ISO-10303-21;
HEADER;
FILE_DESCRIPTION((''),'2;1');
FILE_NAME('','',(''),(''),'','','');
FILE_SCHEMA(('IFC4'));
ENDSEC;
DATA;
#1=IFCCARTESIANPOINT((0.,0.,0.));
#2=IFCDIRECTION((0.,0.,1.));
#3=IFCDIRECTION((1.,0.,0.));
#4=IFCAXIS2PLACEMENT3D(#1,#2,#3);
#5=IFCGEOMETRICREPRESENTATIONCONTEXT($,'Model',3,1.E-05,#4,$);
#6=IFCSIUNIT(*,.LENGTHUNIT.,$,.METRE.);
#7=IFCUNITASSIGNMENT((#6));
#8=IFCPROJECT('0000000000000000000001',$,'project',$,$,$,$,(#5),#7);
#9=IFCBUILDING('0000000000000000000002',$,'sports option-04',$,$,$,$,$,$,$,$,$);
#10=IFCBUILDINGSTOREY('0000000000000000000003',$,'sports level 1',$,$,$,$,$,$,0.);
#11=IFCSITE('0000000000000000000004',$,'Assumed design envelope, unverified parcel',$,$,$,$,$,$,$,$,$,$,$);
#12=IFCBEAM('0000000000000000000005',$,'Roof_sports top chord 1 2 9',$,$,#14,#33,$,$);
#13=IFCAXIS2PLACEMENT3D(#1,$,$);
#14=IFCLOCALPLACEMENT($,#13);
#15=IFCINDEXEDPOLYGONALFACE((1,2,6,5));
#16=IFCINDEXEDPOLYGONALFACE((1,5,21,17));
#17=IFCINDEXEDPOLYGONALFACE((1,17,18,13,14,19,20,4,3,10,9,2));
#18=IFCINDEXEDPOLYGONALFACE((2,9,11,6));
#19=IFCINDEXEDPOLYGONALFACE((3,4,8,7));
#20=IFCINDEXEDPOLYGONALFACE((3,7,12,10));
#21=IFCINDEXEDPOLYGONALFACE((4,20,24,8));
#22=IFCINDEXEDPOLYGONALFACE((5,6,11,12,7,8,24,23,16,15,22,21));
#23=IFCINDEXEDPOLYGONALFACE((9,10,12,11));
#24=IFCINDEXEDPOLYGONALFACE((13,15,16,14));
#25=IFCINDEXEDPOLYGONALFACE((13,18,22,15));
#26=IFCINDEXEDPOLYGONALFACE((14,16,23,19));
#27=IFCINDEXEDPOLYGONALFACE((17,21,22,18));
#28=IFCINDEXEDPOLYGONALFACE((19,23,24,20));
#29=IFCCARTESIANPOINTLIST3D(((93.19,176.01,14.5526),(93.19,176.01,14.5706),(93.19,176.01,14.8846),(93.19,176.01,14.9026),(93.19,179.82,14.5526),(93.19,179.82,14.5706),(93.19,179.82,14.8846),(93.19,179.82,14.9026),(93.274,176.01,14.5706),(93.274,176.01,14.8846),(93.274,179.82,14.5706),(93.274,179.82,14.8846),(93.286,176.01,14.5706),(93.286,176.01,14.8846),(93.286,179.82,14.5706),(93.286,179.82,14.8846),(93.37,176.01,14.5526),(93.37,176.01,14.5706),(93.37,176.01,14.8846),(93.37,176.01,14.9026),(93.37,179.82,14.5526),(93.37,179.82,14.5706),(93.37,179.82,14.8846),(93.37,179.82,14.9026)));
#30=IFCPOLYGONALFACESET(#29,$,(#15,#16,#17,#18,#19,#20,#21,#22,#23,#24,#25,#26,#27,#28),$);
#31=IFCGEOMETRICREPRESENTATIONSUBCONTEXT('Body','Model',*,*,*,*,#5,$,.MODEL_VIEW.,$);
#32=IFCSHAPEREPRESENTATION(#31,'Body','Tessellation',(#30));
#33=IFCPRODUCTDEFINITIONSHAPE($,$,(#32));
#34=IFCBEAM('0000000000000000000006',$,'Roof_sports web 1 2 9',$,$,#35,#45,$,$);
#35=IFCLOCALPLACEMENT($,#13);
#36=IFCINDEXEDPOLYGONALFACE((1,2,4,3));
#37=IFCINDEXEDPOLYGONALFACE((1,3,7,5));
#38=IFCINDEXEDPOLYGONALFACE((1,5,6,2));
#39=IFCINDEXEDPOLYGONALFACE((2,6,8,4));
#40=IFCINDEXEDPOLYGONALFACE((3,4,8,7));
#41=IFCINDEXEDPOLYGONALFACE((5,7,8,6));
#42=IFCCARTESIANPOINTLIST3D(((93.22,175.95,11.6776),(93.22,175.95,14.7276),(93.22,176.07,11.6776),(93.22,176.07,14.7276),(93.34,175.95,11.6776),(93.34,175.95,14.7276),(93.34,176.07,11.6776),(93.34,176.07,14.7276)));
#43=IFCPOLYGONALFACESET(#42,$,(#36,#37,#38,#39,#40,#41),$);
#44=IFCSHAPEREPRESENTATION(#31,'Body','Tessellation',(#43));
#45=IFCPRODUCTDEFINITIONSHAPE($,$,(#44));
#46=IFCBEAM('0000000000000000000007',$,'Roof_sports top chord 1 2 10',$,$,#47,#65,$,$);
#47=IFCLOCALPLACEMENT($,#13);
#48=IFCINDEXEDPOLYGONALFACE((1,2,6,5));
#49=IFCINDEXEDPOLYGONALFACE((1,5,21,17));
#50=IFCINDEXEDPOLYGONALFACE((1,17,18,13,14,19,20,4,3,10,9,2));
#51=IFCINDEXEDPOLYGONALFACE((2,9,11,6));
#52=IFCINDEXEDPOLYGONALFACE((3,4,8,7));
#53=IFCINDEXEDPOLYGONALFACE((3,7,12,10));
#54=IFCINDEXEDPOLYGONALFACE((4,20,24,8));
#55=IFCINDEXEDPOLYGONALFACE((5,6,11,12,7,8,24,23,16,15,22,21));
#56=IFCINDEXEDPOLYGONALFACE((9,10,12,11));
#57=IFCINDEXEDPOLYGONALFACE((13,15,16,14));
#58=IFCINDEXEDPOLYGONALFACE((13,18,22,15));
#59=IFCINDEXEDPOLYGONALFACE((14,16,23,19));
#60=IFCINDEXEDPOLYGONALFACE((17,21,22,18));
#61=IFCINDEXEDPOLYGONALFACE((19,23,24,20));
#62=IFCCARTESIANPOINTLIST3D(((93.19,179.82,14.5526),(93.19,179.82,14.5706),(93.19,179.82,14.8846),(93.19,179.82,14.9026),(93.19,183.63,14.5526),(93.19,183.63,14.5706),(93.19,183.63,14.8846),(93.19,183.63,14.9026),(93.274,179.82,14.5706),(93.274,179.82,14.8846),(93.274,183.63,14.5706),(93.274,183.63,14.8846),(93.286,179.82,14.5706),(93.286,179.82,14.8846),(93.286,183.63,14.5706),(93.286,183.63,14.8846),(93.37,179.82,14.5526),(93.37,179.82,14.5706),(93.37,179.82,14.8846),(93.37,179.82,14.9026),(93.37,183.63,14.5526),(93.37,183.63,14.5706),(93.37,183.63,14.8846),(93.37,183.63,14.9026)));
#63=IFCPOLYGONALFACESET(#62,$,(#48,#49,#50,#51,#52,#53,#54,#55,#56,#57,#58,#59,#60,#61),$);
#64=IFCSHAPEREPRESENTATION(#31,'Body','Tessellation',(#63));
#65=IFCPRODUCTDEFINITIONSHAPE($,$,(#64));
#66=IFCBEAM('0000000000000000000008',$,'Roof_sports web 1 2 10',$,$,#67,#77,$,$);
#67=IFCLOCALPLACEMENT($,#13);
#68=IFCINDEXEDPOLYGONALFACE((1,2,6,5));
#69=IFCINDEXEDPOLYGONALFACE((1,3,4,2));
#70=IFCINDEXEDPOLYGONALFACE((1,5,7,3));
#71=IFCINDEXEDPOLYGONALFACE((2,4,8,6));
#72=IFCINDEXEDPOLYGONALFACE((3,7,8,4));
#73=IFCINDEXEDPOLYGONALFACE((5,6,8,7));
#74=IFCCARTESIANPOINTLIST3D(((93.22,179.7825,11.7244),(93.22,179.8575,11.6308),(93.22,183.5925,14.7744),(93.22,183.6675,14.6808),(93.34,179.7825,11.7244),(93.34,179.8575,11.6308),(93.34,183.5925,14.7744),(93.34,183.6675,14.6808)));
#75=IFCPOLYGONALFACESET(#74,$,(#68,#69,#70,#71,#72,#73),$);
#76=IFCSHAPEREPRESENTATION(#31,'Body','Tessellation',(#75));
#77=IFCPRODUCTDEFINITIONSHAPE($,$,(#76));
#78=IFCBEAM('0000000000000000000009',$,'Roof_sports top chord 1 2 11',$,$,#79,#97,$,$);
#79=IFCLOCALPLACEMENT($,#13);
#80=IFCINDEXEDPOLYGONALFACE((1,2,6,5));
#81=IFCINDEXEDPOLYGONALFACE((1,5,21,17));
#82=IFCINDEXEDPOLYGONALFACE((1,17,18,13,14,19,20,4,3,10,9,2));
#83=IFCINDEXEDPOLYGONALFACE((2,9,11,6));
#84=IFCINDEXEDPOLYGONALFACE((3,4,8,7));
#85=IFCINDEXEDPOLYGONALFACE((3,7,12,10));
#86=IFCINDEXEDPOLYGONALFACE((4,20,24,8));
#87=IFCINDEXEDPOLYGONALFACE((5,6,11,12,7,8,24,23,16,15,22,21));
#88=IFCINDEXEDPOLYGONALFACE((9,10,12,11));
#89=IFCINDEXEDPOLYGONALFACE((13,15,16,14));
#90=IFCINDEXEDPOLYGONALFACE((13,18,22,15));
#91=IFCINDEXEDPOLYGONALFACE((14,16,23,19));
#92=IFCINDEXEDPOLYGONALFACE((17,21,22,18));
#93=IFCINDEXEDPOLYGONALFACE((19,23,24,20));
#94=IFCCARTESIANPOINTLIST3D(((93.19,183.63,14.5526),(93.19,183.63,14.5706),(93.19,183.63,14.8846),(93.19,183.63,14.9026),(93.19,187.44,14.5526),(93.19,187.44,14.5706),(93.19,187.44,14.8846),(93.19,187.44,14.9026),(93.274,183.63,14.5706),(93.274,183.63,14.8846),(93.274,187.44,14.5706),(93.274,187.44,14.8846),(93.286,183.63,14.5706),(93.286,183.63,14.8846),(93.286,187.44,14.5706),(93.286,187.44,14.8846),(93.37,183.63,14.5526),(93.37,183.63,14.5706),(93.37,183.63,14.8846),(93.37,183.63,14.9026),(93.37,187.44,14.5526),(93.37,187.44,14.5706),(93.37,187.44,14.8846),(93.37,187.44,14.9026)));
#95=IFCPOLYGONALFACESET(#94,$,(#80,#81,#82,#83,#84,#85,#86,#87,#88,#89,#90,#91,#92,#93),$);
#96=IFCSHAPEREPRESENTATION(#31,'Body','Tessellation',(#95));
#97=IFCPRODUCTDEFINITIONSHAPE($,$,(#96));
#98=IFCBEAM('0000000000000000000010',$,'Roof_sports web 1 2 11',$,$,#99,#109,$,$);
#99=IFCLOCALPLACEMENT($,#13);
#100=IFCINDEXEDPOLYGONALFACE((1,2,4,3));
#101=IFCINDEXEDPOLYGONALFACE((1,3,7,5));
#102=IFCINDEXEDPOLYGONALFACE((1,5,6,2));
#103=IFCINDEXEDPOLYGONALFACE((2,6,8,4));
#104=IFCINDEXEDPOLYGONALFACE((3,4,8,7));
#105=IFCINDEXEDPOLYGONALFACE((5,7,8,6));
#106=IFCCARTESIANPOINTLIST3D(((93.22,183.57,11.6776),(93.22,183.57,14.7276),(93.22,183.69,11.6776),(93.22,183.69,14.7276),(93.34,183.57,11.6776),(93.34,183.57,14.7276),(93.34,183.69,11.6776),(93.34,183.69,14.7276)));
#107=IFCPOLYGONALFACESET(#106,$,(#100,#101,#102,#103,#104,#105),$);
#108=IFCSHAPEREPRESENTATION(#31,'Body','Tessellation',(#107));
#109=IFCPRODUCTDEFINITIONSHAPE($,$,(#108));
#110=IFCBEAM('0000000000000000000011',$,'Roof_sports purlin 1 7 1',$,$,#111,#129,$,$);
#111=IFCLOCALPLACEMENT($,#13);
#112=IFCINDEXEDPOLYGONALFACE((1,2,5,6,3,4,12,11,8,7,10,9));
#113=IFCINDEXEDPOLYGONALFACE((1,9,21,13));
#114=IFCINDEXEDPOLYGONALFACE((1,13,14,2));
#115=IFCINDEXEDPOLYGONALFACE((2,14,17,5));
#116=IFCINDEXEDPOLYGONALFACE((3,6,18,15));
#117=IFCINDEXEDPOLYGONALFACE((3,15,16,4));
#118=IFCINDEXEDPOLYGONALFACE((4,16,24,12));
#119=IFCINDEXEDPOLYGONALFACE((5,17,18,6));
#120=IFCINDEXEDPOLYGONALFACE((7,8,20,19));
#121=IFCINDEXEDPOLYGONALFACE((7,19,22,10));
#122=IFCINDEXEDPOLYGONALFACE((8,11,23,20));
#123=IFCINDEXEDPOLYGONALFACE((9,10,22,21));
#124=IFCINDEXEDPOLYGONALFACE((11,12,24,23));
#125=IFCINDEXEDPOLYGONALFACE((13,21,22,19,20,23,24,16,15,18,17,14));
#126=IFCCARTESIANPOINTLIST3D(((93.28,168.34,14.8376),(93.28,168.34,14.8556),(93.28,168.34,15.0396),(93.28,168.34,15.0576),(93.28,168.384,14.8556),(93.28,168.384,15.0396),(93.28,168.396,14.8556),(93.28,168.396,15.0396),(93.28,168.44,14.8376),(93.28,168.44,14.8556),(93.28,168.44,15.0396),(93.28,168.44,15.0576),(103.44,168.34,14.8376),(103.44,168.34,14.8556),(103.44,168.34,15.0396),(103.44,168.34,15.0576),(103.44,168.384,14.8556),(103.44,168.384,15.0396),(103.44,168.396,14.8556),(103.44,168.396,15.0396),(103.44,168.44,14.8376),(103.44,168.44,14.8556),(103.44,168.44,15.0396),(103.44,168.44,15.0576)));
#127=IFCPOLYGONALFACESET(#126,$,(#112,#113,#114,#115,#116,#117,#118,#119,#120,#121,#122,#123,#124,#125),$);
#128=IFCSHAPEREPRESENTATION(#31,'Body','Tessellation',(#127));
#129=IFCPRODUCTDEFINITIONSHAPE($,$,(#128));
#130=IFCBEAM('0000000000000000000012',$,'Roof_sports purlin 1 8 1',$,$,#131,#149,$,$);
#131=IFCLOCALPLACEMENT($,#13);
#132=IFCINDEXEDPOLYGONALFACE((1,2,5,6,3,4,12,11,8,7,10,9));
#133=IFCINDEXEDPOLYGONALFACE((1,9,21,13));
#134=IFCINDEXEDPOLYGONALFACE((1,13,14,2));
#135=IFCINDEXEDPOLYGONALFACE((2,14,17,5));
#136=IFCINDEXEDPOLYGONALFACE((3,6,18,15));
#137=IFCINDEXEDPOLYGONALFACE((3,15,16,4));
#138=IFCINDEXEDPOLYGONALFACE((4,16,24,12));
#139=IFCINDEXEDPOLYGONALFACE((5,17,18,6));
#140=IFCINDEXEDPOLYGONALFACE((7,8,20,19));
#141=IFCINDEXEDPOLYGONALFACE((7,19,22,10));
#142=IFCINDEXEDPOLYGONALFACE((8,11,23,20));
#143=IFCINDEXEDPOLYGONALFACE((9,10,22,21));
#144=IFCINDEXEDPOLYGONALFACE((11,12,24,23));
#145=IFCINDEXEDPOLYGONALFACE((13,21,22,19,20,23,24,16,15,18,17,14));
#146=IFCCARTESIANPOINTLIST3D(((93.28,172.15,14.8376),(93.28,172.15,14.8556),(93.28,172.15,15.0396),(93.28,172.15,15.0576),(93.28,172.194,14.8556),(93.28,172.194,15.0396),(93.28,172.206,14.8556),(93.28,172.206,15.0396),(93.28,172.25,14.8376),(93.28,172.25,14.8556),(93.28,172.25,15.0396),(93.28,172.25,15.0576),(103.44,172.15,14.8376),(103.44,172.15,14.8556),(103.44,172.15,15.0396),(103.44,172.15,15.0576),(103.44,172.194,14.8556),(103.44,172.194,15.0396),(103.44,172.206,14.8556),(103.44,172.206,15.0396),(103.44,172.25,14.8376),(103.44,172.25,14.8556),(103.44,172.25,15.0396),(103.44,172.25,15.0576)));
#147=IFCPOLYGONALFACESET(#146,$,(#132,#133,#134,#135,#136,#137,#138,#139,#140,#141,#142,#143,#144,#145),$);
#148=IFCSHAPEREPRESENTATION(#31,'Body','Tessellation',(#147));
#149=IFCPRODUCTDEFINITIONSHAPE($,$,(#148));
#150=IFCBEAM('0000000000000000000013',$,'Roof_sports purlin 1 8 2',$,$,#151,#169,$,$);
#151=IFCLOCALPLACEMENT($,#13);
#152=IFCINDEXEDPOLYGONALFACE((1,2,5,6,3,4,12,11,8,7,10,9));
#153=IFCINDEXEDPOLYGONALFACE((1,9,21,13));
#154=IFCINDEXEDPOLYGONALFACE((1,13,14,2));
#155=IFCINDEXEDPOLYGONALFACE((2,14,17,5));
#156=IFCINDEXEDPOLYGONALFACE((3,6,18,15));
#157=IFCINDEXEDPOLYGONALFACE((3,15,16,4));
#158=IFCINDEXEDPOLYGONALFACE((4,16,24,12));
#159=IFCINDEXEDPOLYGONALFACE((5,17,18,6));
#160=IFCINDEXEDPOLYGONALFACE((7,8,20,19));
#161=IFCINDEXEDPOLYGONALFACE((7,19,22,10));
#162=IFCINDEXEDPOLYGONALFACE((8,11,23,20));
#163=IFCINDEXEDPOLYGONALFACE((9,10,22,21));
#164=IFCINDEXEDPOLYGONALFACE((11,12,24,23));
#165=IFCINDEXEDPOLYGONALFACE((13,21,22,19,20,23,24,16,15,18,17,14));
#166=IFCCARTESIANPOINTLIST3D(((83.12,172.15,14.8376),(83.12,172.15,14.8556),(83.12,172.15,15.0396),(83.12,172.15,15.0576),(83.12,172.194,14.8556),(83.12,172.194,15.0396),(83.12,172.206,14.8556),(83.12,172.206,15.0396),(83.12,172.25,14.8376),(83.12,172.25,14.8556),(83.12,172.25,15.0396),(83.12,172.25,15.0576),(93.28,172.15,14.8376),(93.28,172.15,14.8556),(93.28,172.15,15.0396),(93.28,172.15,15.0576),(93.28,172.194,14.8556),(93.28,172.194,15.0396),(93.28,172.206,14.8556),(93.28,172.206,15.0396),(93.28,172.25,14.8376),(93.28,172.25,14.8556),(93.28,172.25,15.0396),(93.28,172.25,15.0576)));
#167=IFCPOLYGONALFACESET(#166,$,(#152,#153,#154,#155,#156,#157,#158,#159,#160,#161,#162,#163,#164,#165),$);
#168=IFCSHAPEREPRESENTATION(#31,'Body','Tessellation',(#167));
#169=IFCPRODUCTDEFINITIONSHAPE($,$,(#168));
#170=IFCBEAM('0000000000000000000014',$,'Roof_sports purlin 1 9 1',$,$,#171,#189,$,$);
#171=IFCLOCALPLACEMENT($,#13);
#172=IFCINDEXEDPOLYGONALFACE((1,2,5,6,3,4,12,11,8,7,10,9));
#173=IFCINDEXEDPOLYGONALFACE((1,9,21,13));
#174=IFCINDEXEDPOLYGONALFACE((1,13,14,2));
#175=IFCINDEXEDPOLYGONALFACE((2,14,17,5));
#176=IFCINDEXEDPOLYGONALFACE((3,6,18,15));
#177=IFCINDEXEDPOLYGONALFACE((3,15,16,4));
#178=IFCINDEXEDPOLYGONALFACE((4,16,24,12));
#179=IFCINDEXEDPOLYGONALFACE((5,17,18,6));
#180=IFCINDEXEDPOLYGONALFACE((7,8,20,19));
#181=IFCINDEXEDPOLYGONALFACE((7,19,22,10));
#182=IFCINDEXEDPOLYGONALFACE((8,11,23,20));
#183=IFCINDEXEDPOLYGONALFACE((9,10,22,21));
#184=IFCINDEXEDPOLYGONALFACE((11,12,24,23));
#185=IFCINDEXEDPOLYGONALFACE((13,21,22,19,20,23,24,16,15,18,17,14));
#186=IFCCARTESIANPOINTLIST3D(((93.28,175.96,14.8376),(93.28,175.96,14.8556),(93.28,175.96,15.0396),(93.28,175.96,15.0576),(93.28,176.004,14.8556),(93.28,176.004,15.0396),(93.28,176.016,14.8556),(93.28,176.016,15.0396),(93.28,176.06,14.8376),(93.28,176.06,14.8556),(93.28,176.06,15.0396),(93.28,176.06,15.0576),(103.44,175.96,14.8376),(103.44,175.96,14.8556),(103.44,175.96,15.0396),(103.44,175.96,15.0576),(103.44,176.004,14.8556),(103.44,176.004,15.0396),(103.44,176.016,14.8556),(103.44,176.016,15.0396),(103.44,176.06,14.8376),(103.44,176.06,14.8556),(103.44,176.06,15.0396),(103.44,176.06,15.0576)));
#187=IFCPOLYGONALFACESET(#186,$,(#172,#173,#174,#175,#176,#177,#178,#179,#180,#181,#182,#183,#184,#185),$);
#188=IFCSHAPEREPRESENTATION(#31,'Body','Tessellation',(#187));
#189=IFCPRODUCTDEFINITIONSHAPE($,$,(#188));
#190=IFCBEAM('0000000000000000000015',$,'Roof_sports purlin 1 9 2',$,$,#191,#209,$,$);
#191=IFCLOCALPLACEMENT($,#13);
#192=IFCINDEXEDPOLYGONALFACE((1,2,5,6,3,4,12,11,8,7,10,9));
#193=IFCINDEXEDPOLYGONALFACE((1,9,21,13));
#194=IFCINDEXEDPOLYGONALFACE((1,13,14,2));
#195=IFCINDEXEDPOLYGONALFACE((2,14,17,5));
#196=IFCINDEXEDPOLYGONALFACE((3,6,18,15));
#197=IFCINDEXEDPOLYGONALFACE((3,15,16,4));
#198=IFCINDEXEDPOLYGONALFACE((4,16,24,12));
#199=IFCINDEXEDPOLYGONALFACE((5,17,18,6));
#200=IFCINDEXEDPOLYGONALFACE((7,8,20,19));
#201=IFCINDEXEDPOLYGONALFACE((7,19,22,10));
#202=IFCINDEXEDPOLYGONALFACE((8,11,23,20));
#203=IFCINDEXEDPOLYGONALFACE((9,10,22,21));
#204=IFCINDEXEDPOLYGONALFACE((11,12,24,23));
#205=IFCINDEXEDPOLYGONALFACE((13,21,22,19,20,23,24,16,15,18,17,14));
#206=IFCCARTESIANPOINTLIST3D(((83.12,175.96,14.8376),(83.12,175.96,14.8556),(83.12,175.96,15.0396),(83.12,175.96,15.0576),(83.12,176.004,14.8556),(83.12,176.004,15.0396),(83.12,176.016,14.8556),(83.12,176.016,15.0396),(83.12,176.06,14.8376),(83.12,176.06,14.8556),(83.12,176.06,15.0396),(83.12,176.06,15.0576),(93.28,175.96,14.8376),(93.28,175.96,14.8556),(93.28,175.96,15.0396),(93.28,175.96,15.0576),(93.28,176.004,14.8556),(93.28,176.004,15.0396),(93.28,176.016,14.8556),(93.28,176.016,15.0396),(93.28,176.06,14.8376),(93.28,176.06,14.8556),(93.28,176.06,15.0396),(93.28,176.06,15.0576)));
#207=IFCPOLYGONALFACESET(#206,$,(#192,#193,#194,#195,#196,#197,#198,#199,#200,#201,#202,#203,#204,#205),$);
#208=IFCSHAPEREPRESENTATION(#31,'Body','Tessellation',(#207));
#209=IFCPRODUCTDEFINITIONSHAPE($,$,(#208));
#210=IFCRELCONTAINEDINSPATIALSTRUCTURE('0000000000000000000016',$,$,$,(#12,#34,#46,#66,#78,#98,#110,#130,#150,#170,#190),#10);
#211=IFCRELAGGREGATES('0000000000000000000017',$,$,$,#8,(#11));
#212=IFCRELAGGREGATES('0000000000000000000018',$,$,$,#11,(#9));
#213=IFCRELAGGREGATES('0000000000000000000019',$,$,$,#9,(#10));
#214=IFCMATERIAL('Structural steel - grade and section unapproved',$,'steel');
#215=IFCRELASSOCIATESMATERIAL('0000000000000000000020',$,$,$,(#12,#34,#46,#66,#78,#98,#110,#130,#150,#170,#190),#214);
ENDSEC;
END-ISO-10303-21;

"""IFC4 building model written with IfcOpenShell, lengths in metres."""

from ifc_helpers import new_model, si_unit, frame, origin_with_axes, place, context, subcontext, project, spatial, rectangle, i_section, extrude, material, element, save


model = new_model("IFC4")

# Units and contexts
model_context = context("Model", 3, precision=1e-05, world=origin_with_axes())
body_context = subcontext(model_context, "Body", "Model", "MODEL_VIEW")
ifc_project = project(units=[si_unit("LENGTHUNIT", "METRE")], contexts=[model_context])

# Site, building, storey
site = spatial("IfcSite", under=ifc_project, Name="Assumed design envelope, unverified parcel")
building = spatial("IfcBuilding", under=site, Name="sports option-04")
storey = spatial("IfcBuildingStorey", under=building, Name="sports level 1", Elevation=0.0)

# Shared definitions
ifc_material_1 = material(Name="Structural steel - grade and section unapproved", Category="steel")

# Beams
beam_1_placement = place(None, frame((93.28, 176.01, 14.7276), z_axis=(0.0, 1.0, 0.0), x_axis=(-1.0, 0.0, 0.0)))
element("IfcBeam", 1, at=beam_1_placement, inside=storey, material=ifc_material_1, Name="Roof_sports top chord 1 2 9", context=body_context, shape_type="SweptSolid", body=[
    extrude(i_section(OverallWidth=0.18, OverallDepth=0.35, WebThickness=0.012, FlangeThickness=0.018, FilletRadius=0.0), origin_with_axes(), (0.0, 0.0, 1.0), 3.81),
])
beam_2_placement = place(None, frame((93.28, 176.01, 11.6776), z_axis=(0.0, 0.0, 1.0), x_axis=(-1.0, 0.0, 0.0)))
element("IfcBeam", 2, at=beam_2_placement, inside=storey, material=ifc_material_1, Name="Roof_sports web 1 2 9", context=body_context, shape_type="SweptSolid", body=[
    extrude(rectangle(XDim=0.12, YDim=0.12), origin_with_axes(), (0.0, 0.0, 1.0), 3.05),
])
beam_3_placement = place(None, frame((93.28, 179.82, 14.7276), z_axis=(0.0, 1.0, 0.0), x_axis=(-1.0, 0.0, 0.0)))
element("IfcBeam", 3, at=beam_3_placement, inside=storey, material=ifc_material_1, Name="Roof_sports top chord 1 2 10", context=body_context, shape_type="SweptSolid", body=[
    extrude(i_section(OverallWidth=0.18, OverallDepth=0.35, WebThickness=0.012, FlangeThickness=0.018, FilletRadius=0.0), origin_with_axes(), (0.0, 0.0, 1.0), 3.81),
])
beam_4_placement = place(None, frame((93.28, 179.82, 11.6776), z_axis=(0.0, 0.780669, 0.624945), x_axis=(-1.0, 0.0, 0.0)))
element("IfcBeam", 4, at=beam_4_placement, inside=storey, material=ifc_material_1, Name="Roof_sports web 1 2 10", context=body_context, shape_type="SweptSolid", body=[
    extrude(rectangle(XDim=0.12, YDim=0.12), origin_with_axes(), (0.0, 0.0, 1.0), 4.8804),
])
beam_5_placement = place(None, frame((93.28, 183.63, 14.7276), z_axis=(0.0, 1.0, 0.0), x_axis=(-1.0, 0.0, 0.0)))
element("IfcBeam", 5, at=beam_5_placement, inside=storey, material=ifc_material_1, Name="Roof_sports top chord 1 2 11", context=body_context, shape_type="SweptSolid", body=[
    extrude(i_section(OverallWidth=0.18, OverallDepth=0.35, WebThickness=0.012, FlangeThickness=0.018, FilletRadius=0.0), origin_with_axes(), (0.0, 0.0, 1.0), 3.81),
])
beam_6_placement = place(None, frame((93.28, 183.63, 11.6776), z_axis=(0.0, 0.0, 1.0), x_axis=(-1.0, 0.0, 0.0)))
element("IfcBeam", 6, at=beam_6_placement, inside=storey, material=ifc_material_1, Name="Roof_sports web 1 2 11", context=body_context, shape_type="SweptSolid", body=[
    extrude(rectangle(XDim=0.12, YDim=0.12), origin_with_axes(), (0.0, 0.0, 1.0), 3.05),
])
for number, where, z_axis, x_axis, name in (
    (7, (103.44, 168.39, 14.9476), (-1.0, 0.0, 0.0), (0.0, -1.0, 0.0), "Roof_sports purlin 1 7 1"),
    (8, (103.44, 172.2, 14.9476), (-1.0, 0.0, 0.0), (0.0, -1.0, 0.0), "Roof_sports purlin 1 8 1"),
):
    element("IfcBeam", number, at=place(None, frame(where, z_axis=z_axis, x_axis=x_axis)), inside=storey, material=ifc_material_1, Name=name, context=body_context, shape_type="SweptSolid", body=[
        extrude(i_section(OverallWidth=0.1, OverallDepth=0.22, WebThickness=0.012, FlangeThickness=0.018, FilletRadius=0.0), origin_with_axes(), (0.0, 0.0, 1.0), 10.16),
    ])
beam_7_placement = place(None, frame((93.28, 172.2, 14.9476), z_axis=(-1.0, 0.0, 0.0), x_axis=(0.0, -1.0, 0.0)))
element("IfcBeam", 9, at=beam_7_placement, inside=storey, material=ifc_material_1, Name="Roof_sports purlin 1 8 2", context=body_context, shape_type="SweptSolid", body=[
    extrude(i_section(OverallWidth=0.1, OverallDepth=0.22, WebThickness=0.012, FlangeThickness=0.018, FilletRadius=0.0), origin_with_axes(), (0.0, 0.0, 1.0), 10.16),
])
beam_8_placement = place(None, frame((103.44, 176.01, 14.9476), z_axis=(-1.0, 0.0, 0.0), x_axis=(0.0, -1.0, 0.0)))
element("IfcBeam", 10, at=beam_8_placement, inside=storey, material=ifc_material_1, Name="Roof_sports purlin 1 9 1", context=body_context, shape_type="SweptSolid", body=[
    extrude(i_section(OverallWidth=0.1, OverallDepth=0.22, WebThickness=0.012, FlangeThickness=0.018, FilletRadius=0.0), origin_with_axes(), (0.0, 0.0, 1.0), 10.16),
])
beam_9_placement = place(None, frame((93.28, 176.01, 14.9476), z_axis=(-1.0, 0.0, 0.0), x_axis=(0.0, -1.0, 0.0)))
element("IfcBeam", 11, at=beam_9_placement, inside=storey, material=ifc_material_1, Name="Roof_sports purlin 1 9 2", context=body_context, shape_type="SweptSolid", body=[
    extrude(i_section(OverallWidth=0.1, OverallDepth=0.22, WebThickness=0.012, FlangeThickness=0.018, FilletRadius=0.0), origin_with_axes(), (0.0, 0.0, 1.0), 10.16),
])

save(model, "model.ifc")
